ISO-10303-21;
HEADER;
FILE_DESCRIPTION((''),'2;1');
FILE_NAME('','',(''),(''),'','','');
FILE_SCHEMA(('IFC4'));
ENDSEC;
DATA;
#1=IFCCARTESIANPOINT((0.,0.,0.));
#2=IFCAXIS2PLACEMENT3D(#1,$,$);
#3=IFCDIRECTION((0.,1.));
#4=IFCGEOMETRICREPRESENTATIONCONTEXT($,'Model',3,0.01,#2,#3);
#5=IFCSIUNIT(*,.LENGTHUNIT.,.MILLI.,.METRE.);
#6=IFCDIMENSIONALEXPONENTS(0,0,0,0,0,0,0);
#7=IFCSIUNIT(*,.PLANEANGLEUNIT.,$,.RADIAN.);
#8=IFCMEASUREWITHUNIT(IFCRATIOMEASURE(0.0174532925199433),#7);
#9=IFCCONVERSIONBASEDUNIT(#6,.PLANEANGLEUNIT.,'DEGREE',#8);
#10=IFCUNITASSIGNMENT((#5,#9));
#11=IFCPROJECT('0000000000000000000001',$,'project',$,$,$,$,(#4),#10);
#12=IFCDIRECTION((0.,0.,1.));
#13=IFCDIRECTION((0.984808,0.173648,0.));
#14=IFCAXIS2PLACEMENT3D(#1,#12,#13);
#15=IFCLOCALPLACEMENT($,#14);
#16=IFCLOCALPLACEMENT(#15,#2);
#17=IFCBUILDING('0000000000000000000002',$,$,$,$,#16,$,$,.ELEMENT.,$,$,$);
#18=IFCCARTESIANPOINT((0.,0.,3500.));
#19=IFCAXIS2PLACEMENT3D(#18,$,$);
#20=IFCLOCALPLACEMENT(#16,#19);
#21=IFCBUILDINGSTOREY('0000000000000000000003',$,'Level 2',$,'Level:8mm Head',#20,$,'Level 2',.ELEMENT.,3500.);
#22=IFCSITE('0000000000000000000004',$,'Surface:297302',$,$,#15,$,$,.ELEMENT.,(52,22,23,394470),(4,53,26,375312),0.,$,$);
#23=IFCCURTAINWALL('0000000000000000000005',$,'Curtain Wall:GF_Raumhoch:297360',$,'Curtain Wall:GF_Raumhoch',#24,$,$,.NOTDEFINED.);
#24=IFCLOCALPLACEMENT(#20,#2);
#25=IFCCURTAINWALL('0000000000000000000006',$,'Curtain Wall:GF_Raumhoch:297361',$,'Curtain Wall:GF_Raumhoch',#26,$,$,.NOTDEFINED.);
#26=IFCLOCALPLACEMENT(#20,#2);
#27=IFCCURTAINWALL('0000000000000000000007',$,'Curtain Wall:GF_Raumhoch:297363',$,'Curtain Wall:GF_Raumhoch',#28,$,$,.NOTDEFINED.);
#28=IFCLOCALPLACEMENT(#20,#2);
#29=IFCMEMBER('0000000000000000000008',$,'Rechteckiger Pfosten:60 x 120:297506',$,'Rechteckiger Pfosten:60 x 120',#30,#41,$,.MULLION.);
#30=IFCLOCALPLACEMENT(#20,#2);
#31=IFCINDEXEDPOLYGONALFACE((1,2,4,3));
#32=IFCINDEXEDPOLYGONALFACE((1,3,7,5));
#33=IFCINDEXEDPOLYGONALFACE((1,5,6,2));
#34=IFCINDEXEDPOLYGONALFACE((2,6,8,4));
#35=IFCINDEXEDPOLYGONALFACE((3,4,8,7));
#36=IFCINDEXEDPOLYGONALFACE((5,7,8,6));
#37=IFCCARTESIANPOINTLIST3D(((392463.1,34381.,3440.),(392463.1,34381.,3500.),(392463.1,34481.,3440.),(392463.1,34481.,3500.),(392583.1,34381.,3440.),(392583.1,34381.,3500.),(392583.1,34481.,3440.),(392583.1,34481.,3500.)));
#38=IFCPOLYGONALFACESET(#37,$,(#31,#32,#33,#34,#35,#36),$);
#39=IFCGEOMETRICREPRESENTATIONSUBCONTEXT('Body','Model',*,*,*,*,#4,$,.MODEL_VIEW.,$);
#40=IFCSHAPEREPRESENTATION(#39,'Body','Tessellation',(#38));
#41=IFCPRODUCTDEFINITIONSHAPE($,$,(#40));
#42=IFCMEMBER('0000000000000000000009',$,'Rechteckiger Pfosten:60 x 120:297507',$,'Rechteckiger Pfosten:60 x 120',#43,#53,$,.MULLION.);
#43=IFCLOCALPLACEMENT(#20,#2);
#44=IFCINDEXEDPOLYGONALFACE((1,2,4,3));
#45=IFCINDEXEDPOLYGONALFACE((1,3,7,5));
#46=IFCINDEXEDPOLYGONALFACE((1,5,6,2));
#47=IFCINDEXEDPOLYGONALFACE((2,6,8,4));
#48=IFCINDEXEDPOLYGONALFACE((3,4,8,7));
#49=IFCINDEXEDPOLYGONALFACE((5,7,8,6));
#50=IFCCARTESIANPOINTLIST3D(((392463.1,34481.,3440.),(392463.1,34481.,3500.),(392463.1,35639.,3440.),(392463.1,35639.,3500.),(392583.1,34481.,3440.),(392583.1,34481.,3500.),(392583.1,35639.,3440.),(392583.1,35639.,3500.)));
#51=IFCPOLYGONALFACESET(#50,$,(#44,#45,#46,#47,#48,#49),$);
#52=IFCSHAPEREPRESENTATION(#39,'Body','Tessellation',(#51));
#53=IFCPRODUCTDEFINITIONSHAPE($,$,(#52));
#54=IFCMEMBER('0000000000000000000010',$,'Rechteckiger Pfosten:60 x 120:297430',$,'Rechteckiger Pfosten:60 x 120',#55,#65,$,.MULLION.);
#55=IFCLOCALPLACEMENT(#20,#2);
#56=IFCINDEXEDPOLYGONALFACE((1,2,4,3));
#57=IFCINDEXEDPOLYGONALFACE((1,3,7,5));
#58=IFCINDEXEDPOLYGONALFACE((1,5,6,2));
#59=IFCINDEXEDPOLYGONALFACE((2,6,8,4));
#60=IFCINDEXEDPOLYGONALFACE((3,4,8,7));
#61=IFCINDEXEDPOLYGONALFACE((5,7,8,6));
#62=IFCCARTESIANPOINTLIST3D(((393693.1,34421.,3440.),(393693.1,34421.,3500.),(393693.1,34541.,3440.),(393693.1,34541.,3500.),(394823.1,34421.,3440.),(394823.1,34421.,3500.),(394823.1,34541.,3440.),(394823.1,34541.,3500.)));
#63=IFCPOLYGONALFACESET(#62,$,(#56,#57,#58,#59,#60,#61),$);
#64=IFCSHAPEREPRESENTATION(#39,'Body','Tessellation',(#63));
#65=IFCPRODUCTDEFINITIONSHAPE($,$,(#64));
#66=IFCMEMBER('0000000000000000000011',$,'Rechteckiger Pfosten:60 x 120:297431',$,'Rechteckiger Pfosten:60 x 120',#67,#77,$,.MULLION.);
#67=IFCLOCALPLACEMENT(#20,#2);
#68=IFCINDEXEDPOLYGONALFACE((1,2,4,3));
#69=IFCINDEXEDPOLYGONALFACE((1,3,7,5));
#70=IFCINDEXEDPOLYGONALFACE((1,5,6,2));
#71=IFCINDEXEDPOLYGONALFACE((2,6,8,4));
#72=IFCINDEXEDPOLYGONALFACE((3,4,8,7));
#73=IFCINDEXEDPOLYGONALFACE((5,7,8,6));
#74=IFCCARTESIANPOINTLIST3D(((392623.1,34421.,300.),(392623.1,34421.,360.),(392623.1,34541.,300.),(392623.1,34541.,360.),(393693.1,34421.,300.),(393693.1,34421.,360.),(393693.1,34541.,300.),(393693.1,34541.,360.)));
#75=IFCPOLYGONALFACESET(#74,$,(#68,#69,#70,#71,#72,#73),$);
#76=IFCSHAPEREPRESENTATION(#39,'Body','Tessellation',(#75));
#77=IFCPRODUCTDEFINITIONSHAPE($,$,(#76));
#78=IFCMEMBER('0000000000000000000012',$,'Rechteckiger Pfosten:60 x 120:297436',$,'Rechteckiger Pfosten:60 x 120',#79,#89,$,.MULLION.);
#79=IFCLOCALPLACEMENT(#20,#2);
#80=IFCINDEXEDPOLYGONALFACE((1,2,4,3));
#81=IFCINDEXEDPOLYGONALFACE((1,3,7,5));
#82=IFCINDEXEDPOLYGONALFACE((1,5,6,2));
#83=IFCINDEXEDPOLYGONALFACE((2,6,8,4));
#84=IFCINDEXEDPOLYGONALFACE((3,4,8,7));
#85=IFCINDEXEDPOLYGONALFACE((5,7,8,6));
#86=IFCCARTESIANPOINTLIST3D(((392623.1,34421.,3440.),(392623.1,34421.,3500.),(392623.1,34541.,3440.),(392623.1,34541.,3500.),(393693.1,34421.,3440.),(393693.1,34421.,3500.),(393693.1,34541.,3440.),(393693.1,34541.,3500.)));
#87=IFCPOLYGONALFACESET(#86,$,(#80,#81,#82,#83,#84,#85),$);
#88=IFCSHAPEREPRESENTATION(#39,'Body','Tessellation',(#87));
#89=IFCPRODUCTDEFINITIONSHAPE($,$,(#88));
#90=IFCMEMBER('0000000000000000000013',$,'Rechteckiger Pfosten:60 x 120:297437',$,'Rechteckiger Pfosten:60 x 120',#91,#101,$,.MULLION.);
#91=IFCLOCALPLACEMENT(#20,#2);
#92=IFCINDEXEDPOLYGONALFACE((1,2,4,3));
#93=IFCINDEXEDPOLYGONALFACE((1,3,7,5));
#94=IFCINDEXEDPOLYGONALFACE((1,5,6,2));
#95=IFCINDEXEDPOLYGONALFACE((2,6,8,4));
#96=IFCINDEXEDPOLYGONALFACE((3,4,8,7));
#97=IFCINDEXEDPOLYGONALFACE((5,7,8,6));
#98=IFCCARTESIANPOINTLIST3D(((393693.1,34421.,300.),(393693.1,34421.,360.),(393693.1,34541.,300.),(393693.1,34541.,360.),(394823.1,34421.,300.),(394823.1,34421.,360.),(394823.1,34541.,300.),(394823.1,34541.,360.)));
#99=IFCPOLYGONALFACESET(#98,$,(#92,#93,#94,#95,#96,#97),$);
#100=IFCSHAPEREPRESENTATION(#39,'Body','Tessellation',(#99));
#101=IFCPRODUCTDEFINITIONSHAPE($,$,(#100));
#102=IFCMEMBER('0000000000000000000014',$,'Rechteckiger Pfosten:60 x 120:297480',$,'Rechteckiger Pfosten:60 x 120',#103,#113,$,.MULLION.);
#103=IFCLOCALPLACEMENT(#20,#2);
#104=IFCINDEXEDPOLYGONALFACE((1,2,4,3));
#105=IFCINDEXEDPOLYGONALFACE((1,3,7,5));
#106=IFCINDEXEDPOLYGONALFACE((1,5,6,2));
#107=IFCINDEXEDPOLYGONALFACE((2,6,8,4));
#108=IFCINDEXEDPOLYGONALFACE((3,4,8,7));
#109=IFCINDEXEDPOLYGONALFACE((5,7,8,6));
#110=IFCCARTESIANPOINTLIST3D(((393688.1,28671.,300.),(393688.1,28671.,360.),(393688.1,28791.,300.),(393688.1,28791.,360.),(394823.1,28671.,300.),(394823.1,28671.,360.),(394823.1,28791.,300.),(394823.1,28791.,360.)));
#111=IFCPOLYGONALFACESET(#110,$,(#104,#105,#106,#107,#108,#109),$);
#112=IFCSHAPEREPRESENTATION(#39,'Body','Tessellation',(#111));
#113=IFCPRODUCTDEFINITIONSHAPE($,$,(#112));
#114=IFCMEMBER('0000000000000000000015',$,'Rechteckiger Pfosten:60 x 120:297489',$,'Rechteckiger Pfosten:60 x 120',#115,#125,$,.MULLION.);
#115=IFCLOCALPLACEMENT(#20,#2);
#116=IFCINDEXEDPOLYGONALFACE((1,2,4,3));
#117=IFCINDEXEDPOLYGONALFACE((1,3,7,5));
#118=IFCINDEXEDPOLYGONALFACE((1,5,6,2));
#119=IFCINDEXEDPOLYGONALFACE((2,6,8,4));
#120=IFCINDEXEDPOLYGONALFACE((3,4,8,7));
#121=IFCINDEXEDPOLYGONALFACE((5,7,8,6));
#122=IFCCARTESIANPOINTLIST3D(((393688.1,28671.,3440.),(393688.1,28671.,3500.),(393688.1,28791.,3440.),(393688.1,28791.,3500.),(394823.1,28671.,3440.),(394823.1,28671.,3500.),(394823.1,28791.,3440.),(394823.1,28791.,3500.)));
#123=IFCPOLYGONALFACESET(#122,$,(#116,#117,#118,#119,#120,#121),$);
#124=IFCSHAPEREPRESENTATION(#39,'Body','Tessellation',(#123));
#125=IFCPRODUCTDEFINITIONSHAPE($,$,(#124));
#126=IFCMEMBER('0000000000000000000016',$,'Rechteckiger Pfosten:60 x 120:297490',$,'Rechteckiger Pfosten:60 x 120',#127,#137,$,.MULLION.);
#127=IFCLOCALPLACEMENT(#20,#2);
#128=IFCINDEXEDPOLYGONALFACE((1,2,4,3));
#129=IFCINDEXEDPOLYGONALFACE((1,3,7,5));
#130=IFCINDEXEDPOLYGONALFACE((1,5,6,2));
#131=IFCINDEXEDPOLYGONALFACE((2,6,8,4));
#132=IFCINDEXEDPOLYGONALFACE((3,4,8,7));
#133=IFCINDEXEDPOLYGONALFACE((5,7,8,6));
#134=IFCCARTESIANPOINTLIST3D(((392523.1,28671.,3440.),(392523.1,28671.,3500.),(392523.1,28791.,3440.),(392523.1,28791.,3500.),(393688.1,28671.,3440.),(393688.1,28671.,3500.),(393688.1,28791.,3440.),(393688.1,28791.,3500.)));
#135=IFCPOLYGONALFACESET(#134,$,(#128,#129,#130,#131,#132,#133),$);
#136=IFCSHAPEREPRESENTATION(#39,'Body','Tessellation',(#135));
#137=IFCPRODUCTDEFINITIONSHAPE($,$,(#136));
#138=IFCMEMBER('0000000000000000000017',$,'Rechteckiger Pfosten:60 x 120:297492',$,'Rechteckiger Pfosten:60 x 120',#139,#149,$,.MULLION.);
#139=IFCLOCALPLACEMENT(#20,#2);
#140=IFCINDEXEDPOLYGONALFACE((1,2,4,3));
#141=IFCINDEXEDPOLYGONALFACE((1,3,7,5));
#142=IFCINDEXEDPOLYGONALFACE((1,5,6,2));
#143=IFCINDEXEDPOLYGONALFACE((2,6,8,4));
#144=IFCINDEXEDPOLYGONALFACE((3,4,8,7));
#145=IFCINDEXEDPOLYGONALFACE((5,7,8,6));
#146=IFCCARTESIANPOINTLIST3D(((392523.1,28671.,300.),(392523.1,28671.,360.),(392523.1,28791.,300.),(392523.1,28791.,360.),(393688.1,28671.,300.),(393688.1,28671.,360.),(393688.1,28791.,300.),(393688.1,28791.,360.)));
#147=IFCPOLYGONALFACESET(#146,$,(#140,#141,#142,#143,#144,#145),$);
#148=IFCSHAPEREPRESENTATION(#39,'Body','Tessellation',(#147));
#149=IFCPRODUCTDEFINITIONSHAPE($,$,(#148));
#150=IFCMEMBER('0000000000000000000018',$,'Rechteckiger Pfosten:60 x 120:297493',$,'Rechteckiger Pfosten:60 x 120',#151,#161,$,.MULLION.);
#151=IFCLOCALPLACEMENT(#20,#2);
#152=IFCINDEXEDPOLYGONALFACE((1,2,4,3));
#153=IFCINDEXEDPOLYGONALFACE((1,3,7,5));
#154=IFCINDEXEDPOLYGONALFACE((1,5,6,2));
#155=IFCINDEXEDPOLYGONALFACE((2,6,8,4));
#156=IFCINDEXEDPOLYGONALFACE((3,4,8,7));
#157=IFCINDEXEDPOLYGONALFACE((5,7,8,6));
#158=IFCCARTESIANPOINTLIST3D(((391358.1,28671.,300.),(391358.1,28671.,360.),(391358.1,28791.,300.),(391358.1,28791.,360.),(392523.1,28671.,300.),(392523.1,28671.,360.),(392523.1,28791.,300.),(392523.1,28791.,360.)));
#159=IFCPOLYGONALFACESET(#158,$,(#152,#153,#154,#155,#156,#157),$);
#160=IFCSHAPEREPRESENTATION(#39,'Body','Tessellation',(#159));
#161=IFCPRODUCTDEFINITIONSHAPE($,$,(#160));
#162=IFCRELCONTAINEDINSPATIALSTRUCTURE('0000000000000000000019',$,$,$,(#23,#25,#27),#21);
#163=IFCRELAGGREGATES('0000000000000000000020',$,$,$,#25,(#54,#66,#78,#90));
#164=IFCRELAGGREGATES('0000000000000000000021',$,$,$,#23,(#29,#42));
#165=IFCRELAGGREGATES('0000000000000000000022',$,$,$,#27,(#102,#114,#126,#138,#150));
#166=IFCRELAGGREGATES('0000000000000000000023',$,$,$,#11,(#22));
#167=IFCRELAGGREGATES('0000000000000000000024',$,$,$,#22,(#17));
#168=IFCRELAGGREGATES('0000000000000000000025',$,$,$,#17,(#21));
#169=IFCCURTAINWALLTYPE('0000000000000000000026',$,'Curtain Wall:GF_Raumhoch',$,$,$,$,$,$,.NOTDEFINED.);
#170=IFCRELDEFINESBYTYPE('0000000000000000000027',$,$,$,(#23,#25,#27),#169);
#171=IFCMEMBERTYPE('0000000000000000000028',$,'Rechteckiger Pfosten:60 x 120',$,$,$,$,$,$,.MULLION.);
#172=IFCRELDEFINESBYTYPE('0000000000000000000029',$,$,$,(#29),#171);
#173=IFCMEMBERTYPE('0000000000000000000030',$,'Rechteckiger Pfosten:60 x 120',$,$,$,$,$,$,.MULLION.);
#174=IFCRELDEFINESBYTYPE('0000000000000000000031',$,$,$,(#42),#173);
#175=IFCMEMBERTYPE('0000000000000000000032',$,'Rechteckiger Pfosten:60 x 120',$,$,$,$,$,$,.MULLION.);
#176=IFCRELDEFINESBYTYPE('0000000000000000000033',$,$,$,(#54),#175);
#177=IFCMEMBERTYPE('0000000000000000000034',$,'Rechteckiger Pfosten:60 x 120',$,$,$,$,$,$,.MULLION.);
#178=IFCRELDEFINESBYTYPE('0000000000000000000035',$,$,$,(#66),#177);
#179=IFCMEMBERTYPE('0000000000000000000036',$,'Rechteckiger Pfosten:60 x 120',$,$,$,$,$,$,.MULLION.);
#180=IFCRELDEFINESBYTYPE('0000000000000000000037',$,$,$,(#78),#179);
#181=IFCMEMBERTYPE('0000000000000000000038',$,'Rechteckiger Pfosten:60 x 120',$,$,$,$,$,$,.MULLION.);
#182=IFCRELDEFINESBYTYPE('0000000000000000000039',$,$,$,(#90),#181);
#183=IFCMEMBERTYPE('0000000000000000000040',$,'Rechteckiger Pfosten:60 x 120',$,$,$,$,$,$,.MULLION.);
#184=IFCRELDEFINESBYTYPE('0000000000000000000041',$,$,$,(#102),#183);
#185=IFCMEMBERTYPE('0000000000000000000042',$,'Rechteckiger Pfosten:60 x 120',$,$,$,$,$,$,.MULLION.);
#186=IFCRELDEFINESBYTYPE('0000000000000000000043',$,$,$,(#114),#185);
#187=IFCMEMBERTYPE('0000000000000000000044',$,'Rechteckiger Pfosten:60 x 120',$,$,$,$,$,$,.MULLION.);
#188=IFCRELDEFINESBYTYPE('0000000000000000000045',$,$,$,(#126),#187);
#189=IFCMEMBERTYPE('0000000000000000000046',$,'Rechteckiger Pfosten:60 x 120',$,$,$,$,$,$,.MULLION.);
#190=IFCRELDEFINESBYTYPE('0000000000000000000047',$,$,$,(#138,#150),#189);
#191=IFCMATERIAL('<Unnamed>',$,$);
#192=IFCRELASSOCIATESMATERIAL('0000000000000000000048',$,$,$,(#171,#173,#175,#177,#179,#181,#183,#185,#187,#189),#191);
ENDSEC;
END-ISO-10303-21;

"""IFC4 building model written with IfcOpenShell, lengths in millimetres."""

from ifc_helpers import new_model, entity, si_unit, converted_unit, direction, frame, origin, place, context, subcontext, project, spatial, indexed_curve, outline, extrude, source, transform, mapped, material, type_object, type_shapes, element, aggregate, save


model = new_model("IFC4")

# Units and contexts
model_context = context("Model", 3, precision=0.01, world=origin(), true_north=direction((0.0, 1.0)))
body_context = subcontext(model_context, "Body", "Model", "MODEL_VIEW")
ifc_project = project(units=[si_unit("LENGTHUNIT", "METRE", prefix="MILLI"), converted_unit("PLANEANGLEUNIT", "DEGREE", entity("IfcRatioMeasure", 0.0174532925199433), si_unit("PLANEANGLEUNIT", "RADIAN"), dimensions=[0, 0, 0, 0, 0, 0, 0])], contexts=[model_context])

# Site, building, storey
site_placement = place(None, frame((0.0, 0.0, 0.0), z_axis=(0.0, 0.0, 1.0), x_axis=(0.984808, 0.173648, 0.0)))
site = spatial("IfcSite", under=ifc_project, at=site_placement, Name="Surface:297302", CompositionType="ELEMENT", RefLatitude=(52, 22, 23, 394470), RefLongitude=(4, 53, 26, 375312), RefElevation=0.0)
building_placement = place(site_placement, origin())
building = spatial("IfcBuilding", under=site, at=building_placement, CompositionType="ELEMENT")
storey_placement = place(building_placement, frame((0.0, 0.0, 3500.0)))
storey = spatial("IfcBuildingStorey", under=building, at=storey_placement, Name="Level 2", ObjectType="Level:8mm Head", LongName="Level 2", CompositionType="ELEMENT", Elevation=3500.0)

# Curtain walls
curtain_wall_type = type_object("IfcCurtainWallType", Name="Curtain Wall:GF_Raumhoch", PredefinedType="NOTDEFINED")
ifc_material_1 = material(Name="<Unnamed>")
curtain_wall_1_placement = place(storey_placement, frame((0.0, 0.0, -3500.0)))
curtain_wall_1 = element("IfcCurtainWall", 1, at=curtain_wall_1_placement, inside=storey, type_object=curtain_wall_type, Name="Curtain Wall:GF_Raumhoch:297360", ObjectType="Curtain Wall:GF_Raumhoch", PredefinedType="NOTDEFINED")
curtain_wall_2_placement = place(storey_placement, frame((0.0, 0.0, -3500.0)))
curtain_wall_2 = element("IfcCurtainWall", 2, at=curtain_wall_2_placement, inside=storey, type_object=curtain_wall_type, Name="Curtain Wall:GF_Raumhoch:297361", ObjectType="Curtain Wall:GF_Raumhoch", PredefinedType="NOTDEFINED")

# Curtain wall
curtain_wall_3_placement = place(storey_placement, frame((0.0, 0.0, -3500.0)))
curtain_wall_3 = element("IfcCurtainWall", 3, at=curtain_wall_3_placement, inside=storey, type_object=curtain_wall_type, Name="Curtain Wall:GF_Raumhoch:297363", ObjectType="Curtain Wall:GF_Raumhoch", PredefinedType="NOTDEFINED")

# Members
member_type_1 = type_object("IfcMemberType", Name="Rechteckiger Pfosten:60 x 120", PredefinedType="MULLION", material=ifc_material_1)
shared_shape_1 = source(origin(), body_context, "Body", "SweptSolid", [
    extrude(outline(indexed_curve([(-60.0, -30.0), (60.0, -30.0), (60.0, 30.0), (-60.0, 30.0), (-60.0, -30.0)], self_intersect=False)), frame((-30.0, 0.0, -100.0), z_axis=(0.0, 0.0, 1.0), x_axis=(0.0, -1.0, 0.0)), (0.0, 0.0, 1.0), 100.0),
])
type_shapes(member_type_1, [shared_shape_1])
member_1_placement = place(curtain_wall_1_placement, frame((392523.1, 34381.0, 7000.0), z_axis=(0.0, -1.0, 0.0), x_axis=(0.0, 0.0, 1.0)))
member_1 = element("IfcMember", 4, at=member_1_placement, type_object=member_type_1, Name="Rechteckiger Pfosten:60 x 120:297506", ObjectType="Rechteckiger Pfosten:60 x 120", PredefinedType="MULLION", context=body_context, shape_type="MappedRepresentation", body=[
    mapped(shared_shape_1, transform((0.0, 0.0, 0.0), scale=1.0)),
])
member_type_2 = type_object("IfcMemberType", Name="Rechteckiger Pfosten:60 x 120", PredefinedType="MULLION", material=ifc_material_1)
shared_shape_2 = source(origin(), body_context, "Body", "SweptSolid", [
    extrude(outline(indexed_curve([(-60.0, -30.0), (60.0, -30.0), (60.0, 30.0), (-60.0, 30.0), (-60.0, -30.0)], self_intersect=False)), frame((-30.0, 0.0, -1158.0), z_axis=(0.0, 0.0, 1.0), x_axis=(0.0, -1.0, 0.0)), (0.0, 0.0, 1.0), 1158.0),
])
type_shapes(member_type_2, [shared_shape_2])
member_2_placement = place(curtain_wall_1_placement, frame((392523.1, 34481.0, 7000.0), z_axis=(0.0, -1.0, 0.0), x_axis=(0.0, 0.0, 1.0)))
member_2 = element("IfcMember", 5, at=member_2_placement, type_object=member_type_2, Name="Rechteckiger Pfosten:60 x 120:297507", ObjectType="Rechteckiger Pfosten:60 x 120", PredefinedType="MULLION", context=body_context, shape_type="MappedRepresentation", body=[
    mapped(shared_shape_2, transform((0.0, 0.0, 0.0), scale=1.0)),
])
member_type_3 = type_object("IfcMemberType", Name="Rechteckiger Pfosten:60 x 120", PredefinedType="MULLION", material=ifc_material_1)
shared_shape_3 = source(origin(), body_context, "Body", "SweptSolid", [
    extrude(outline(indexed_curve([(-60.0, -30.0), (60.0, -30.0), (60.0, 30.0), (-60.0, 30.0), (-60.0, -30.0)], self_intersect=False)), frame((-30.0, 0.0, -1130.0), z_axis=(0.0, 0.0, 1.0), x_axis=(0.0, -1.0, 0.0)), (0.0, 0.0, 1.0), 1130.0),
])
type_shapes(member_type_3, [shared_shape_3])
member_3_placement = place(curtain_wall_2_placement, frame((394823.1, 34481.0, 7000.0), z_axis=(1.0, 0.0, 0.0), x_axis=(0.0, 0.0, 1.0)))
member_3 = element("IfcMember", 6, at=member_3_placement, type_object=member_type_3, Name="Rechteckiger Pfosten:60 x 120:297430", ObjectType="Rechteckiger Pfosten:60 x 120", PredefinedType="MULLION", context=body_context, shape_type="MappedRepresentation", body=[
    mapped(shared_shape_3, transform((0.0, 0.0, 0.0), scale=1.0)),
])
member_type_4 = type_object("IfcMemberType", Name="Rechteckiger Pfosten:60 x 120", PredefinedType="MULLION", material=ifc_material_1)
shared_shape_4 = source(origin(), body_context, "Body", "SweptSolid", [
    extrude(outline(indexed_curve([(-60.0, -30.0), (60.0, -30.0), (60.0, 30.0), (-60.0, 30.0), (-60.0, -30.0)], self_intersect=False)), frame((-30.0, 0.0, -1070.0), z_axis=(0.0, 0.0, 1.0), x_axis=(0.0, -1.0, 0.0)), (0.0, 0.0, 1.0), 1070.0),
])
type_shapes(member_type_4, [shared_shape_4])
member_4_placement = place(curtain_wall_2_placement, frame((392623.1, 34481.0, 3800.0), z_axis=(-1.0, 0.0, 0.0), x_axis=(0.0, 0.0, -1.0)))
member_4 = element("IfcMember", 7, at=member_4_placement, type_object=member_type_4, Name="Rechteckiger Pfosten:60 x 120:297431", ObjectType="Rechteckiger Pfosten:60 x 120", PredefinedType="MULLION", context=body_context, shape_type="MappedRepresentation", body=[
    mapped(shared_shape_4, transform((0.0, 0.0, 0.0), scale=1.0)),
])
member_type_5 = type_object("IfcMemberType", Name="Rechteckiger Pfosten:60 x 120", PredefinedType="MULLION", material=ifc_material_1)
shared_shape_5 = source(origin(), body_context, "Body", "SweptSolid", [
    extrude(outline(indexed_curve([(-60.0, -30.0), (60.0, -30.0), (60.0, 30.0), (-60.0, 30.0), (-60.0, -30.0)], self_intersect=False)), frame((-30.0, 0.0, -1070.0), z_axis=(0.0, 0.0, 1.0), x_axis=(0.0, -1.0, 0.0)), (0.0, 0.0, 1.0), 1070.0),
])
type_shapes(member_type_5, [shared_shape_5])
member_5_placement = place(curtain_wall_2_placement, frame((393693.1, 34481.0, 7000.0), z_axis=(1.0, 0.0, 0.0), x_axis=(0.0, 0.0, 1.0)))
member_5 = element("IfcMember", 8, at=member_5_placement, type_object=member_type_5, Name="Rechteckiger Pfosten:60 x 120:297436", ObjectType="Rechteckiger Pfosten:60 x 120", PredefinedType="MULLION", context=body_context, shape_type="MappedRepresentation", body=[
    mapped(shared_shape_5, transform((0.0, 0.0, 0.0), scale=1.0)),
])
member_type_6 = type_object("IfcMemberType", Name="Rechteckiger Pfosten:60 x 120", PredefinedType="MULLION", material=ifc_material_1)
shared_shape_6 = source(origin(), body_context, "Body", "SweptSolid", [
    extrude(outline(indexed_curve([(-60.0, -30.0), (60.0, -30.0), (60.0, 30.0), (-60.0, 30.0), (-60.0, -30.0)], self_intersect=False)), frame((-30.0, 0.0, -1130.0), z_axis=(0.0, 0.0, 1.0), x_axis=(0.0, -1.0, 0.0)), (0.0, 0.0, 1.0), 1130.0),
])
type_shapes(member_type_6, [shared_shape_6])
member_6_placement = place(curtain_wall_2_placement, frame((393693.1, 34481.0, 3800.0), z_axis=(-1.0, 0.0, 0.0), x_axis=(0.0, 0.0, -1.0)))
member_6 = element("IfcMember", 9, at=member_6_placement, type_object=member_type_6, Name="Rechteckiger Pfosten:60 x 120:297437", ObjectType="Rechteckiger Pfosten:60 x 120", PredefinedType="MULLION", context=body_context, shape_type="MappedRepresentation", body=[
    mapped(shared_shape_6, transform((0.0, 0.0, 0.0), scale=1.0)),
])
member_type_7 = type_object("IfcMemberType", Name="Rechteckiger Pfosten:60 x 120", PredefinedType="MULLION", material=ifc_material_1)
shared_shape_7 = source(origin(), body_context, "Body", "SweptSolid", [
    extrude(outline(indexed_curve([(-60.0, -30.0), (60.0, -30.0), (60.0, 30.0), (-60.0, 30.0), (-60.0, -30.0)], self_intersect=False)), frame((-30.0, 0.0, -1135.0), z_axis=(0.0, 0.0, 1.0), x_axis=(0.0, -1.0, 0.0)), (0.0, 0.0, 1.0), 1135.0),
])
type_shapes(member_type_7, [shared_shape_7])
member_7_placement = place(curtain_wall_3_placement, frame((394823.1, 28731.0, 3800.0), z_axis=(1.0, 0.0, 0.0), x_axis=(0.0, 0.0, -1.0)))
member_7 = element("IfcMember", 10, at=member_7_placement, type_object=member_type_7, Name="Rechteckiger Pfosten:60 x 120:297480", ObjectType="Rechteckiger Pfosten:60 x 120", PredefinedType="MULLION", context=body_context, shape_type="MappedRepresentation", body=[
    mapped(shared_shape_7, transform((0.0, 0.0, 0.0), scale=1.0)),
])
member_type_8 = type_object("IfcMemberType", Name="Rechteckiger Pfosten:60 x 120", PredefinedType="MULLION", material=ifc_material_1)
shared_shape_8 = source(origin(), body_context, "Body", "SweptSolid", [
    extrude(outline(indexed_curve([(-60.0, -30.0), (60.0, -30.0), (60.0, 30.0), (-60.0, 30.0), (-60.0, -30.0)], self_intersect=False)), frame((-30.0, 0.0, -1135.0), z_axis=(0.0, 0.0, 1.0), x_axis=(0.0, -1.0, 0.0)), (0.0, 0.0, 1.0), 1135.0),
])
type_shapes(member_type_8, [shared_shape_8])
member_8_placement = place(curtain_wall_3_placement, frame((393688.1, 28731.0, 7000.0), z_axis=(-1.0, 0.0, 0.0), x_axis=(0.0, 0.0, 1.0)))
member_8 = element("IfcMember", 11, at=member_8_placement, type_object=member_type_8, Name="Rechteckiger Pfosten:60 x 120:297489", ObjectType="Rechteckiger Pfosten:60 x 120", PredefinedType="MULLION", context=body_context, shape_type="MappedRepresentation", body=[
    mapped(shared_shape_8, transform((0.0, 0.0, 0.0), scale=1.0)),
])
member_type_9 = type_object("IfcMemberType", Name="Rechteckiger Pfosten:60 x 120", PredefinedType="MULLION", material=ifc_material_1)
shared_shape_9 = source(origin(), body_context, "Body", "SweptSolid", [
    extrude(outline(indexed_curve([(-60.0, -30.0), (60.0, -30.0), (60.0, 30.0), (-60.0, 30.0), (-60.0, -30.0)], self_intersect=False)), frame((-30.0, 0.0, -1165.0), z_axis=(0.0, 0.0, 1.0), x_axis=(0.0, -1.0, 0.0)), (0.0, 0.0, 1.0), 1165.0),
])
type_shapes(member_type_9, [shared_shape_9])
member_9_placement = place(curtain_wall_3_placement, frame((392523.1, 28731.0, 7000.0), z_axis=(-1.0, 0.0, 0.0), x_axis=(0.0, 0.0, 1.0)))
member_9 = element("IfcMember", 12, at=member_9_placement, type_object=member_type_9, Name="Rechteckiger Pfosten:60 x 120:297490", ObjectType="Rechteckiger Pfosten:60 x 120", PredefinedType="MULLION", context=body_context, shape_type="MappedRepresentation", body=[
    mapped(shared_shape_9, transform((0.0, 0.0, 0.0), scale=1.0)),
])
member_type_10 = type_object("IfcMemberType", Name="Rechteckiger Pfosten:60 x 120", PredefinedType="MULLION", material=ifc_material_1)
shared_shape_10 = source(origin(), body_context, "Body", "SweptSolid", [
    extrude(outline(indexed_curve([(-60.0, -30.0), (60.0, -30.0), (60.0, 30.0), (-60.0, 30.0), (-60.0, -30.0)], self_intersect=False)), frame((-30.0, 0.0, -1165.0), z_axis=(0.0, 0.0, 1.0), x_axis=(0.0, -1.0, 0.0)), (0.0, 0.0, 1.0), 1165.0),
])
type_shapes(member_type_10, [shared_shape_10])
member_10_placement = place(curtain_wall_3_placement, frame((393688.1, 28731.0, 3800.0), z_axis=(1.0, 0.0, 0.0), x_axis=(0.0, 0.0, -1.0)))
member_10 = element("IfcMember", 13, at=member_10_placement, type_object=member_type_10, Name="Rechteckiger Pfosten:60 x 120:297492", ObjectType="Rechteckiger Pfosten:60 x 120", PredefinedType="MULLION", context=body_context, shape_type="MappedRepresentation", body=[
    mapped(shared_shape_10, transform((0.0, 0.0, 0.0), scale=1.0)),
])
member_11_placement = place(curtain_wall_3_placement, frame((392523.1, 28731.0, 3800.0), z_axis=(1.0, 0.0, 0.0), x_axis=(0.0, 0.0, -1.0)))
member_11 = element("IfcMember", 14, at=member_11_placement, type_object=member_type_10, Name="Rechteckiger Pfosten:60 x 120:297493", ObjectType="Rechteckiger Pfosten:60 x 120", PredefinedType="MULLION", context=body_context, shape_type="MappedRepresentation", body=[
    mapped(shared_shape_10, transform((0.0, 0.0, 0.0), scale=1.0)),
])

aggregate(curtain_wall_2, [member_3, member_4, member_5, member_6])
aggregate(curtain_wall_1, [member_1, member_2])
aggregate(curtain_wall_3, [member_7, member_8, member_9, member_10, member_11])

save(model, "model.ifc")
